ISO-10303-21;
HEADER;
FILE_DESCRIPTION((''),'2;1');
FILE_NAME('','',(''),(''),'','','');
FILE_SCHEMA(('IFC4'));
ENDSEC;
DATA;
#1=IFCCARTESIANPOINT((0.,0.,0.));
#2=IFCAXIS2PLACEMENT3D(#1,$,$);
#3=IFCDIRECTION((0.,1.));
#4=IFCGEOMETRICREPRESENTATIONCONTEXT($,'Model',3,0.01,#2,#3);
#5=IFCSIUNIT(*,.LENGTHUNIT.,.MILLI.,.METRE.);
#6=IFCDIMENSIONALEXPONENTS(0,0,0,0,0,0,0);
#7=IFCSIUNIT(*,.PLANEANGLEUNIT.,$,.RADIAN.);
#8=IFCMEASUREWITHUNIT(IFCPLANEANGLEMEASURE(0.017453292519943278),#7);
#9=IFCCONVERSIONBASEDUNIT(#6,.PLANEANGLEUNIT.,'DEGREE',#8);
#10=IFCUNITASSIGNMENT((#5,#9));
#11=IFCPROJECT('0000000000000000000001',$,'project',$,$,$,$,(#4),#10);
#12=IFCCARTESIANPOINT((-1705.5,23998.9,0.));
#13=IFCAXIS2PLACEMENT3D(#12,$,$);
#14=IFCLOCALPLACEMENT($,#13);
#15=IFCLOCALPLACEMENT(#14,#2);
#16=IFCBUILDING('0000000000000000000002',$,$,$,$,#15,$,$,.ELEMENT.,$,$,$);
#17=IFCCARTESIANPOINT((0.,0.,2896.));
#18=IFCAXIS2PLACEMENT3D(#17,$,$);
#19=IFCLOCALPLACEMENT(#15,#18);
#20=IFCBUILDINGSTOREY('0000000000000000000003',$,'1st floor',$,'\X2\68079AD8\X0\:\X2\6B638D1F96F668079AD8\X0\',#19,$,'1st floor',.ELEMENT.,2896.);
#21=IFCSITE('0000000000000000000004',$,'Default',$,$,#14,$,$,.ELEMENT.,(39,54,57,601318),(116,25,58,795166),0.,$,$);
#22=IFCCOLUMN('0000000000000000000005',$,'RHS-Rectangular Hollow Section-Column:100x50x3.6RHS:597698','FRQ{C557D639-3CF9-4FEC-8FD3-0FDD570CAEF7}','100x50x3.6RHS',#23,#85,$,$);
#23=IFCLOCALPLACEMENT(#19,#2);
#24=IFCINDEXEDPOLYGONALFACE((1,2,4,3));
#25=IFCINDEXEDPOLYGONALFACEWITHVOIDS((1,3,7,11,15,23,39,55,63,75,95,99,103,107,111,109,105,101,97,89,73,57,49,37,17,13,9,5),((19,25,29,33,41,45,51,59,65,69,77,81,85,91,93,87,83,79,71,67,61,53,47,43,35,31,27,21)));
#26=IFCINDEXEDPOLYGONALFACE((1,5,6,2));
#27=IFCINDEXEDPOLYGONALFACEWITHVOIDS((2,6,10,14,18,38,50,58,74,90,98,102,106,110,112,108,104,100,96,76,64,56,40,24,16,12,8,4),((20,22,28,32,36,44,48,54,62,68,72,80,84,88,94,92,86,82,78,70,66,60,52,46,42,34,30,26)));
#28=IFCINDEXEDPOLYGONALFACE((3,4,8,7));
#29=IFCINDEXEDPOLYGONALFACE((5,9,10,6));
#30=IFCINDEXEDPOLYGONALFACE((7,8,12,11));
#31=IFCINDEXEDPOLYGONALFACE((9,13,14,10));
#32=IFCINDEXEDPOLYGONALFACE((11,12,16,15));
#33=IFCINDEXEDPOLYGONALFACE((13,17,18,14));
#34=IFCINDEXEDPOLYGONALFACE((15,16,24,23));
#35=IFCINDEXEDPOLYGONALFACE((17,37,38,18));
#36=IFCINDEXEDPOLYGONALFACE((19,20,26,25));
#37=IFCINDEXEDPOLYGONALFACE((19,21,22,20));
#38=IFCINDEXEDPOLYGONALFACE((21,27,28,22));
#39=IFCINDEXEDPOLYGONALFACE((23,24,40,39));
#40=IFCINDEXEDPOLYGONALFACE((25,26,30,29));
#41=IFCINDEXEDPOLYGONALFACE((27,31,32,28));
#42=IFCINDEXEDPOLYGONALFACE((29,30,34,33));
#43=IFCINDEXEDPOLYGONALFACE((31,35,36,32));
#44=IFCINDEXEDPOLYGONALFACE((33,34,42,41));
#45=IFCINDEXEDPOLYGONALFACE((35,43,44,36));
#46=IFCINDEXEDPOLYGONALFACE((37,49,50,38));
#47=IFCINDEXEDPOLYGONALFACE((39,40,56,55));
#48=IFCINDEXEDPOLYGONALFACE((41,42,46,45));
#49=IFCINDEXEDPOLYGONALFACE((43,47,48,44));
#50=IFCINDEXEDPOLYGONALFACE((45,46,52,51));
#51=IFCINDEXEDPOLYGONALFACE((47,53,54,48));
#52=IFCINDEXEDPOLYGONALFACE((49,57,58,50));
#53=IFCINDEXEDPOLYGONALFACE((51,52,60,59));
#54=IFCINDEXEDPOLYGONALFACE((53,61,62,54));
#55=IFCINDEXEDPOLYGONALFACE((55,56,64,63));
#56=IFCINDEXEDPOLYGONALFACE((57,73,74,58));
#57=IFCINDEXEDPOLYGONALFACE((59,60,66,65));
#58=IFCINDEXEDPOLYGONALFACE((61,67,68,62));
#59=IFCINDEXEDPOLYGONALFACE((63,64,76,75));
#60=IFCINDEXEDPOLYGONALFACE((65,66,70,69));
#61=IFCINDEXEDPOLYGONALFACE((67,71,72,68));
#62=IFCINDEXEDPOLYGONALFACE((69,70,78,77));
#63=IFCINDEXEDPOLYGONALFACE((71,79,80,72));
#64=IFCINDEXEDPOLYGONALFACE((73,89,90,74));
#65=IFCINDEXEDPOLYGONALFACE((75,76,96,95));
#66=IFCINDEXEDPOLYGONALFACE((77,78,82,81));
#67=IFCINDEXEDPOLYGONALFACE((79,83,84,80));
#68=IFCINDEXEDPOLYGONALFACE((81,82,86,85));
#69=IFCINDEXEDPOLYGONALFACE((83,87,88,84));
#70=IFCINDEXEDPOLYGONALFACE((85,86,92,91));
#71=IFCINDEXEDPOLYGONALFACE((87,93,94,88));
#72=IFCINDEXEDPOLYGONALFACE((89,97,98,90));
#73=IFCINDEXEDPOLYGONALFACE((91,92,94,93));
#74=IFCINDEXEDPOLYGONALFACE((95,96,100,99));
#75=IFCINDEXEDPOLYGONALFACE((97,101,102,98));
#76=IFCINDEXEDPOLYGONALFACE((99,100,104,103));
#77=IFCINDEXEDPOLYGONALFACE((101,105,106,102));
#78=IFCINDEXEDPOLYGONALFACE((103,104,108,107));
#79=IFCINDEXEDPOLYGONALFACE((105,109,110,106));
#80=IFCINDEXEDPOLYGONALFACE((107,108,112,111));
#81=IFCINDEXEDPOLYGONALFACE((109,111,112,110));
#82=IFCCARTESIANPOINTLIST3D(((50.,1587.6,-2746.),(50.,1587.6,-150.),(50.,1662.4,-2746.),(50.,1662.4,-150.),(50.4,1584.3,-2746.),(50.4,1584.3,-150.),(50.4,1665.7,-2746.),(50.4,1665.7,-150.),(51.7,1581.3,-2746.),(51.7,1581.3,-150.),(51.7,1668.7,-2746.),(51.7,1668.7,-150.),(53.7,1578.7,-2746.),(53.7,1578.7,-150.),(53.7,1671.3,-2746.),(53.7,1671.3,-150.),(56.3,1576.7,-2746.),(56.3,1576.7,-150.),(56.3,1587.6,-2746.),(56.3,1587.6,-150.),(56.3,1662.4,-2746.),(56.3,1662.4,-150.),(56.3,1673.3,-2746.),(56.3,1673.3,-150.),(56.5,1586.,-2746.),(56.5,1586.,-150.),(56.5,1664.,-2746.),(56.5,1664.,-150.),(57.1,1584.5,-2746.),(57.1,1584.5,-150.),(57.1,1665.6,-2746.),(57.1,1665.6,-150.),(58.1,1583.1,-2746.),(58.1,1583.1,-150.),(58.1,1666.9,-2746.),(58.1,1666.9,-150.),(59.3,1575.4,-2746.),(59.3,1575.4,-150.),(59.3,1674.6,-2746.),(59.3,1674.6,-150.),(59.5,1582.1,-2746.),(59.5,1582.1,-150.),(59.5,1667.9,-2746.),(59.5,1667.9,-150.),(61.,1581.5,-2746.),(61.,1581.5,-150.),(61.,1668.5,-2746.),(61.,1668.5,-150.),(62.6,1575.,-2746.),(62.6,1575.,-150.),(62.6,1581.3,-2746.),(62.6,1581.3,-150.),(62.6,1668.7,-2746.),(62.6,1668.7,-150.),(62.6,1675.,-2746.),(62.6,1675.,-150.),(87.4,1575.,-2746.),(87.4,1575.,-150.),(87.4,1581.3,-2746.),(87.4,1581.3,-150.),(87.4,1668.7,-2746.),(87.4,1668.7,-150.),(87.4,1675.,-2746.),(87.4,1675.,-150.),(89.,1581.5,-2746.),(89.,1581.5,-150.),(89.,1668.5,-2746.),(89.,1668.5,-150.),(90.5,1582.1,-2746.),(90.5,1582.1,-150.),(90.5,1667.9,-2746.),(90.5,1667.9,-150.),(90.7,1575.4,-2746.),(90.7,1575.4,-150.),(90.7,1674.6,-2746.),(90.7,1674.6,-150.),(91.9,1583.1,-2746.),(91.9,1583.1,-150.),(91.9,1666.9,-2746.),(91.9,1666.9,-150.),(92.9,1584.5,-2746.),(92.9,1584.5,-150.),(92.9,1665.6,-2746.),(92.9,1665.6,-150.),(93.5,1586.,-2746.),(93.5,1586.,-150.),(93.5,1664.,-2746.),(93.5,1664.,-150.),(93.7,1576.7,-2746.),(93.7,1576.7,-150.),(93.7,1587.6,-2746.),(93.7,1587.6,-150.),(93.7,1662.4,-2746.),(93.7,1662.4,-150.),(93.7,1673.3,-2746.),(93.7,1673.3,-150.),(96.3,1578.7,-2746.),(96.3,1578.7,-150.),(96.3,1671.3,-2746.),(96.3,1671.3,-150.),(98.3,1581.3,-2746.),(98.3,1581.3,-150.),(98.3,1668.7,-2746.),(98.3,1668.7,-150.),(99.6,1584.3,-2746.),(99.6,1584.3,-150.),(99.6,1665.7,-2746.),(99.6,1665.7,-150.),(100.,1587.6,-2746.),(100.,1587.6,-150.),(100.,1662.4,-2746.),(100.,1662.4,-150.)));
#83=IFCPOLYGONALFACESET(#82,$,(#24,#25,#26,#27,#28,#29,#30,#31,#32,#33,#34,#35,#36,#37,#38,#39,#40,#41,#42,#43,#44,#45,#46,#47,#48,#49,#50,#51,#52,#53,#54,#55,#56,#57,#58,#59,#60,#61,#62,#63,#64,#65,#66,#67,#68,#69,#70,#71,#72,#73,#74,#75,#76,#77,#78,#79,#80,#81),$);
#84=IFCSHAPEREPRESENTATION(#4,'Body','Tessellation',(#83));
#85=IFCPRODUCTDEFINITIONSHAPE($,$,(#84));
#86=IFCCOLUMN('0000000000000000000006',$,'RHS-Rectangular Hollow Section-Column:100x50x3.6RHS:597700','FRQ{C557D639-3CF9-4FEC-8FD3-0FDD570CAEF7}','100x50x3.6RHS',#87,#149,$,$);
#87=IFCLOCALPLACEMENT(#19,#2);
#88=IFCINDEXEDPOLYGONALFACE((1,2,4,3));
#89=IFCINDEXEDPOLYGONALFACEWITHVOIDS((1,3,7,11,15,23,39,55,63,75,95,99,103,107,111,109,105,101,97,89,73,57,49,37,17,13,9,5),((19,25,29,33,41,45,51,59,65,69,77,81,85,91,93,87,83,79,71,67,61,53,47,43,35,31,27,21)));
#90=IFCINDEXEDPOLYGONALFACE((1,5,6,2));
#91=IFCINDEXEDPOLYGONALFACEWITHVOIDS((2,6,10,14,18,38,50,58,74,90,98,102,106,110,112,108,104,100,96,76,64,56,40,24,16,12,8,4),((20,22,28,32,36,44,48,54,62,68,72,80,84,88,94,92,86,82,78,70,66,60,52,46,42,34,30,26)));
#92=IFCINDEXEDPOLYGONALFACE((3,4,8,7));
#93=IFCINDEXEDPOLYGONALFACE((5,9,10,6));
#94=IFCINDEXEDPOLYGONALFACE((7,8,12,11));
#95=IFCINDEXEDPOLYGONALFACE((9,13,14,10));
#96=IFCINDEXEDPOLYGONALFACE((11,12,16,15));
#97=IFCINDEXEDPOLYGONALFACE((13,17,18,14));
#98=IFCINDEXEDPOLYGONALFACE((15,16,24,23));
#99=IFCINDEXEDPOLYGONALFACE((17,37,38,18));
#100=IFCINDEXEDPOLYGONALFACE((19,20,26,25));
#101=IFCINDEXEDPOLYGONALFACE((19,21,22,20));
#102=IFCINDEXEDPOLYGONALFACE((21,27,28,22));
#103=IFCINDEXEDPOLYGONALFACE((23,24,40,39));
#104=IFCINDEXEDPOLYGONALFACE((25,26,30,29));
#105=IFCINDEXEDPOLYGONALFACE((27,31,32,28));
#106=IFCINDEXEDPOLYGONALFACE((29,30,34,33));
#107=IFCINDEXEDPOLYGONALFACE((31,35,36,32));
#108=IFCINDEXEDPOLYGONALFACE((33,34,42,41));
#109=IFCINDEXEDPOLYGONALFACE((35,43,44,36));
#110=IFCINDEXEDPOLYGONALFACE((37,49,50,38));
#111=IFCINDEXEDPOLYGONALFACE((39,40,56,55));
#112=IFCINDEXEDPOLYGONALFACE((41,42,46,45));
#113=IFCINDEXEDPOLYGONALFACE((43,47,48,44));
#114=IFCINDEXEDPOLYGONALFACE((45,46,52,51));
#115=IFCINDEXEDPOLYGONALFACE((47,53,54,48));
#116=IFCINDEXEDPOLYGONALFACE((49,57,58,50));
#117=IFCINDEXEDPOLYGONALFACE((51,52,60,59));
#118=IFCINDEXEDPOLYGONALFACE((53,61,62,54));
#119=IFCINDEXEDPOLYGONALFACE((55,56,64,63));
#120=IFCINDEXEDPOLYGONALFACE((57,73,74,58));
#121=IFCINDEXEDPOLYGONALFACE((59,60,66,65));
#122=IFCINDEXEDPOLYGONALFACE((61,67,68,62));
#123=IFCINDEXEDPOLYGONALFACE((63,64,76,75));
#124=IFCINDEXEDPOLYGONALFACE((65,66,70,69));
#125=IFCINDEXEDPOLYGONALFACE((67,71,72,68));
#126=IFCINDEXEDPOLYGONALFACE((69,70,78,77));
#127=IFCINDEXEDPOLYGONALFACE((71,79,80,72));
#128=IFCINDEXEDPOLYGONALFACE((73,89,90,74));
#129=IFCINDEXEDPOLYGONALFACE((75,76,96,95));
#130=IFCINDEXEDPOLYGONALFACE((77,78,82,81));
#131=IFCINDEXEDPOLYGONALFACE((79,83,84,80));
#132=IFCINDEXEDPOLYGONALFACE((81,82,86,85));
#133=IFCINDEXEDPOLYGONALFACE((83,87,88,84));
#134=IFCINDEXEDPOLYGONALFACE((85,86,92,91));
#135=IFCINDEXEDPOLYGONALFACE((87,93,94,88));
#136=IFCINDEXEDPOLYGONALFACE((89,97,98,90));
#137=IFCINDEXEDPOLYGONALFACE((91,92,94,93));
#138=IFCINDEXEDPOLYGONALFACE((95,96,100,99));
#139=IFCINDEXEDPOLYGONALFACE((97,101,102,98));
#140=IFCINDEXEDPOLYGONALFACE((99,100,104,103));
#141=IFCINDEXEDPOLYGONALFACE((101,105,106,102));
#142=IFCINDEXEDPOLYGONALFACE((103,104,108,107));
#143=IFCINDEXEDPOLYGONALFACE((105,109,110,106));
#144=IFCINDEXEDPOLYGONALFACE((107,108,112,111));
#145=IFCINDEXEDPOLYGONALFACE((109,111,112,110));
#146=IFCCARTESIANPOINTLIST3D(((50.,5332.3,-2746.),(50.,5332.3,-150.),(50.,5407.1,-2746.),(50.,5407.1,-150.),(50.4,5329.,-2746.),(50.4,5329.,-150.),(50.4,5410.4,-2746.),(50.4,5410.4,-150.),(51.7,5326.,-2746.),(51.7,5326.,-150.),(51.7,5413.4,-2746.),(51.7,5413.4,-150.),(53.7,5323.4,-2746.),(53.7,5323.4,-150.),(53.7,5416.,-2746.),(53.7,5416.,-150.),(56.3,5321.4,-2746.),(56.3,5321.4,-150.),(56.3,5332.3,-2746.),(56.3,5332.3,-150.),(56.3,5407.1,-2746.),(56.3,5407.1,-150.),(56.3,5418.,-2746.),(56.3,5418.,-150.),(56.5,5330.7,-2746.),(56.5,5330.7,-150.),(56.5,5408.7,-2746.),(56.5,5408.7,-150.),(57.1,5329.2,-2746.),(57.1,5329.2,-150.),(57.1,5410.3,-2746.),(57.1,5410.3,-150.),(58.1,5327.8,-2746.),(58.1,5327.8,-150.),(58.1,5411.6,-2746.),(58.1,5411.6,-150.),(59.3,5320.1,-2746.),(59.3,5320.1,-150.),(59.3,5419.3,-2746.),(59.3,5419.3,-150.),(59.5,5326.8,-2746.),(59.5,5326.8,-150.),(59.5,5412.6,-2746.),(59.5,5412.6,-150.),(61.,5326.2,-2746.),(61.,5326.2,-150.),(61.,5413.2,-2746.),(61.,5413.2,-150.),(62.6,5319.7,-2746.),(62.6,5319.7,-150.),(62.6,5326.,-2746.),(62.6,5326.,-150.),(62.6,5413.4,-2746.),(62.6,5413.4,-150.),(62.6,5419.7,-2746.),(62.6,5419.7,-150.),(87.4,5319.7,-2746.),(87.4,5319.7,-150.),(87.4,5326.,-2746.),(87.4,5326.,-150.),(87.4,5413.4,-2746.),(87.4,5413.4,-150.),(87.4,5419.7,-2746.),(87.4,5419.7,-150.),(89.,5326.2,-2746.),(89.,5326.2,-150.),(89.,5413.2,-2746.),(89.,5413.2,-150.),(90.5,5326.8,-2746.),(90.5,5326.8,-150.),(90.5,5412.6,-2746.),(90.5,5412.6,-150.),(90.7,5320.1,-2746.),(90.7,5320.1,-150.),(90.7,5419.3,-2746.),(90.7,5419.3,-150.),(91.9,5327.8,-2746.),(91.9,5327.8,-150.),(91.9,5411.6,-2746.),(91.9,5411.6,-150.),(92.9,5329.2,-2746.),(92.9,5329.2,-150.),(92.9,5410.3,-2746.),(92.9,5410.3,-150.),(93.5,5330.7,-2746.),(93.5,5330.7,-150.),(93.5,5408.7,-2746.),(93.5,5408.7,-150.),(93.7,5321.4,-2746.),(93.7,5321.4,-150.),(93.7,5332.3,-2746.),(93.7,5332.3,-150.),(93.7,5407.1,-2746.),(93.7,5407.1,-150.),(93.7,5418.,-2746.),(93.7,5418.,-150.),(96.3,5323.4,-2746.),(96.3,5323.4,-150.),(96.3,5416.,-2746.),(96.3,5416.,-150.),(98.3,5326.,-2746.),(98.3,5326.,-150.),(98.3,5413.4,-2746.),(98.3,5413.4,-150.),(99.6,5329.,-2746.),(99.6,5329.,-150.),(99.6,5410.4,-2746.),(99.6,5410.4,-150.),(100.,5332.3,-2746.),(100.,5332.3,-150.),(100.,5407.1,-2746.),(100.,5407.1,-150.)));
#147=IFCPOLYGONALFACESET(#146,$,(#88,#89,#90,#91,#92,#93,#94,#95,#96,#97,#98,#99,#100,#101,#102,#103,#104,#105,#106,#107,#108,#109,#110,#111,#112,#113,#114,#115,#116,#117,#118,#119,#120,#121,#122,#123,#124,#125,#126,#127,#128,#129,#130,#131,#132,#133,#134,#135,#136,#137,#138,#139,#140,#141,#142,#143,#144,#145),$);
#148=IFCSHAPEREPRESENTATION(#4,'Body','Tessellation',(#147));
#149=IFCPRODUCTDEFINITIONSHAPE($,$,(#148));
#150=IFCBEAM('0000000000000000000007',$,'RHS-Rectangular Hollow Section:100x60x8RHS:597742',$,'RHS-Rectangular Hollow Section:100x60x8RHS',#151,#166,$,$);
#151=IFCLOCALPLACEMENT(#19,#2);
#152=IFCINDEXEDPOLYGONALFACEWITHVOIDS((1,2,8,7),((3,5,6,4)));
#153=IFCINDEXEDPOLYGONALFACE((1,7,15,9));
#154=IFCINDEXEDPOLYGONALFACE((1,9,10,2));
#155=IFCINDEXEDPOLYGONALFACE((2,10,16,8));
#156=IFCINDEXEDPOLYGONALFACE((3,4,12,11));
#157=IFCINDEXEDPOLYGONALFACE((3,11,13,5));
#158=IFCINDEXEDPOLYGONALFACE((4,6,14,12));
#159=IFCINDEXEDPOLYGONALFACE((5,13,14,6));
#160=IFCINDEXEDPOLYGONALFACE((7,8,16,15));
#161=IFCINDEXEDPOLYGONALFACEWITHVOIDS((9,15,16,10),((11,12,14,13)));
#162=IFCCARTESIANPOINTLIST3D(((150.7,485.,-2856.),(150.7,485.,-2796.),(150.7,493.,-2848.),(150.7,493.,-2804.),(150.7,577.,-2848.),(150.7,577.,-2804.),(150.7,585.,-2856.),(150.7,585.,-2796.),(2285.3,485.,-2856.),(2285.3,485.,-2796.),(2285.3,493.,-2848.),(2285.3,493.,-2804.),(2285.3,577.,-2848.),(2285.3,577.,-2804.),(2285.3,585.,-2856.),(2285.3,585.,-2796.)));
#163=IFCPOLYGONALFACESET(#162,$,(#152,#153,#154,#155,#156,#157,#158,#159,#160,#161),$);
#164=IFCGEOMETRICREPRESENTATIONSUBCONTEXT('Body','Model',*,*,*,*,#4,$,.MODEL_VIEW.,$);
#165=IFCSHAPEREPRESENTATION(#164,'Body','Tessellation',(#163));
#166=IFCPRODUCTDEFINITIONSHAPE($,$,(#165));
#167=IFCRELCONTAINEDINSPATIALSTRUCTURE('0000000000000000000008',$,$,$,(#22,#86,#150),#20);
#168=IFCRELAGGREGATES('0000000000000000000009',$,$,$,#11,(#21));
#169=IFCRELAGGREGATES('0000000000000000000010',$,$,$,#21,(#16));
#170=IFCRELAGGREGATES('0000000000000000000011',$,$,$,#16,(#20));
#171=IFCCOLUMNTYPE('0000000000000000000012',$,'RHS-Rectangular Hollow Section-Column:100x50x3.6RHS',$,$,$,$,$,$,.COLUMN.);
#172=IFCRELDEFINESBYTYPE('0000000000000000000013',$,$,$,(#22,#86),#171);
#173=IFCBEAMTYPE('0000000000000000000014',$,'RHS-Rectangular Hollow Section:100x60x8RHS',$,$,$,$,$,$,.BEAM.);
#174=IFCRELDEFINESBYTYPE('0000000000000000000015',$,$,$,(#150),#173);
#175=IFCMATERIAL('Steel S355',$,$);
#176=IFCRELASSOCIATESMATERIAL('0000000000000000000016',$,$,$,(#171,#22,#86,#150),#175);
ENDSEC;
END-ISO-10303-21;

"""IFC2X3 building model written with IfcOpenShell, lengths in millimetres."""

from ifc_helpers import new_model, entity, si_unit, converted_unit, point, direction, frame, frame_2d, origin, origin_2d, place, context, subcontext, project, spatial, circle_curve, line_curve, trimmed, segment, composite_curve, rectangle, hollow_rectangle, outline, extrude, boolean, clip, halfspace, material, type_object, element, save


model = new_model("IFC2X3")

# Units and contexts
model_context = context("Model", 3, precision=0.01, world=origin(), true_north=direction((0.0, 1.0)))
body_context = subcontext(model_context, "Body", "Model", "MODEL_VIEW")
ifc_project = project(units=[si_unit("LENGTHUNIT", "METRE", prefix="MILLI"), converted_unit("PLANEANGLEUNIT", "DEGREE", entity("IfcPlaneAngleMeasure", 0.017453292519943278), si_unit("PLANEANGLEUNIT", "RADIAN"), dimensions=[0, 0, 0, 0, 0, 0, 0])], contexts=[model_context])

# Site, building, storey
site_placement = place(None, frame((-1705.5, 23998.9, 0.0)))
site = spatial("IfcSite", under=ifc_project, at=site_placement, Name="Default", CompositionType="ELEMENT", RefLatitude=(39, 54, 57, 601318), RefLongitude=(116, 25, 58, 795166), RefElevation=0.0)
building_placement = place(site_placement, origin())
building = spatial("IfcBuilding", under=site, at=building_placement, CompositionType="ELEMENT")
storey_placement = place(building_placement, frame((0.0, 0.0, 2896.0)))
storey = spatial("IfcBuildingStorey", under=building, at=storey_placement, Name="1st floor", ObjectType="标高:正负零标高", LongName="1st floor", CompositionType="ELEMENT", Elevation=2896.0)

# Shared definitions
ifc_material_1 = material(Name="Steel S355")

# Columns, openings
column_type_1 = type_object("IfcColumnType", Name="RHS-Rectangular Hollow Section-Column:100x50x3.6RHS", PredefinedType="COLUMN", material=ifc_material_1)
column_1_placement = place(storey_placement, frame((75.0, 1625.0, -19.1)))
column_1 = element("IfcColumn", 1, at=column_1_placement, inside=storey, type_object=column_type_1, material=ifc_material_1, Name="RHS-Rectangular Hollow Section-Column:100x50x3.6RHS:597698", Description="FRQ{C557D639-3CF9-4FEC-8FD3-0FDD570CAEF7}", ObjectType="100x50x3.6RHS", context=model_context, shape_type="Clipping", body=[
    clip(clip(extrude(hollow_rectangle(XDim=50.0, YDim=100.0, WallThickness=6.3, InnerFilletRadius=6.3, OuterFilletRadius=12.6, at=origin_2d()), origin(), (0.0, 0.0, -1.0), 2782.8), halfspace(frame((-75.0, -1625.0, -2726.9), z_axis=(0.0, 0.0, 1.0), x_axis=(1.0, 0.0, 0.0)), True)), halfspace(frame((-75.0, -1625.0, -55.9), z_axis=(0.0, 0.0, -1.0), x_axis=(-1.0, 0.0, 0.0)), True)),
])
opening_1_placement = place(column_1_placement, frame((0.0, -150.1, -130.9), z_axis=(0.0, 1.0, 0.0), x_axis=(-1.0, 0.0, 0.0)))
element("IfcOpeningElement", 2, at=opening_1_placement, cuts=column_1, ObjectType="Opening", context=model_context, shape_type="SweptSolid", body=[
    extrude(outline(composite_curve([segment(trimmed(circle_curve(frame_2d((43.0, 32.0), x_axis=(1.0, 0.0)), 32.0), [point((43.0, 0.0))], [point((75.0, 32.0))], True, "CARTESIAN"), True, "CONTINUOUS"), segment(trimmed(line_curve((75.0, 32.0), (0.0, 1.0), 86.0), [point((75.0, 32.0))], [point((75.0, 118.0))], True, "CARTESIAN"), True, "CONTINUOUS"), segment(trimmed(circle_curve(frame_2d((43.0, 118.0), x_axis=(1.0, 0.0)), 32.0), [point((75.0, 118.0))], [point((43.0, 150.0))], True, "CARTESIAN"), True, "CONTINUOUS"), segment(trimmed(line_curve((43.0, 150.0), (-1.0, 0.0), 86.0), [point((43.0, 150.0))], [point((-43.0, 150.0))], True, "CARTESIAN"), True, "CONTINUOUS"), segment(trimmed(circle_curve(frame_2d((-43.0, 118.0), x_axis=(1.0, 0.0)), 32.0), [point((-43.0, 150.0))], [point((-75.0, 118.0))], True, "CARTESIAN"), True, "CONTINUOUS"), segment(trimmed(line_curve((-75.0, 118.0), (0.0, -1.0), 86.0), [point((-75.0, 118.0))], [point((-75.0, 32.0))], True, "CARTESIAN"), True, "CONTINUOUS"), segment(trimmed(circle_curve(frame_2d((-43.0, 32.0), x_axis=(1.0, 0.0)), 32.0), [point((-75.0, 32.0))], [point((-43.0, 0.0))], True, "CARTESIAN"), True, "CONTINUOUS"), segment(trimmed(line_curve((-43.0, 0.0), (1.0, 0.0), 86.0), [point((-43.0, 0.0))], [point((43.0, 0.0))], True, "CARTESIAN"), True, "CONTINUOUS")], self_intersect="UNKNOWN")), origin(), (0.0, 0.0, 1.0), 300.2),
])
column_2_placement = place(storey_placement, frame((75.0, 5369.7, -19.1)))
column_2 = element("IfcColumn", 3, at=column_2_placement, inside=storey, type_object=column_type_1, material=ifc_material_1, Name="RHS-Rectangular Hollow Section-Column:100x50x3.6RHS:597700", Description="FRQ{C557D639-3CF9-4FEC-8FD3-0FDD570CAEF7}", ObjectType="100x50x3.6RHS", context=model_context, shape_type="Clipping", body=[
    clip(clip(extrude(hollow_rectangle(XDim=50.0, YDim=100.0, WallThickness=6.3, InnerFilletRadius=6.3, OuterFilletRadius=12.6, at=origin_2d()), origin(), (0.0, 0.0, -1.0), 2782.8), halfspace(frame((-75.0, -5369.7, -55.9), z_axis=(0.0, 0.0, -1.0), x_axis=(-1.0, 0.0, 0.0)), True)), halfspace(frame((-75.0, -5369.7, -2726.9), z_axis=(0.0, 0.0, 1.0), x_axis=(1.0, 0.0, 0.0)), True)),
])
opening_2_placement = place(column_2_placement, frame((0.0, -150.1, -130.9), z_axis=(0.0, 1.0, 0.0), x_axis=(-1.0, 0.0, 0.0)))
element("IfcOpeningElement", 4, at=opening_2_placement, cuts=column_2, ObjectType="Opening", context=model_context, shape_type="SweptSolid", body=[
    extrude(outline(composite_curve([segment(trimmed(circle_curve(frame_2d((43.0, 32.0), x_axis=(1.0, 0.0)), 32.0), [point((43.0, 0.0))], [point((75.0, 32.0))], True, "CARTESIAN"), True, "CONTINUOUS"), segment(trimmed(line_curve((75.0, 32.0), (0.0, 1.0), 86.0), [point((75.0, 32.0))], [point((75.0, 118.0))], True, "CARTESIAN"), True, "CONTINUOUS"), segment(trimmed(circle_curve(frame_2d((43.0, 118.0), x_axis=(1.0, 0.0)), 32.0), [point((75.0, 118.0))], [point((43.0, 150.0))], True, "CARTESIAN"), True, "CONTINUOUS"), segment(trimmed(line_curve((43.0, 150.0), (-1.0, 0.0), 86.0), [point((43.0, 150.0))], [point((-43.0, 150.0))], True, "CARTESIAN"), True, "CONTINUOUS"), segment(trimmed(circle_curve(frame_2d((-43.0, 118.0), x_axis=(1.0, 0.0)), 32.0), [point((-43.0, 150.0))], [point((-75.0, 118.0))], True, "CARTESIAN"), True, "CONTINUOUS"), segment(trimmed(line_curve((-75.0, 118.0), (0.0, -1.0), 86.0), [point((-75.0, 118.0))], [point((-75.0, 32.0))], True, "CARTESIAN"), True, "CONTINUOUS"), segment(trimmed(circle_curve(frame_2d((-43.0, 32.0), x_axis=(1.0, 0.0)), 32.0), [point((-75.0, 32.0))], [point((-43.0, 0.0))], True, "CARTESIAN"), True, "CONTINUOUS"), segment(trimmed(line_curve((-43.0, 0.0), (1.0, 0.0), 86.0), [point((-43.0, 0.0))], [point((43.0, 0.0))], True, "CARTESIAN"), True, "CONTINUOUS")], self_intersect="UNKNOWN")), origin(), (0.0, 0.0, 1.0), 300.2),
])

# Beam
beam_type_1 = type_object("IfcBeamType", Name="RHS-Rectangular Hollow Section:100x60x8RHS", PredefinedType="BEAM")
beam_1_placement = place(storey_placement, frame((150.7, 585.0, -2826.0)))
element("IfcBeam", 5, at=beam_1_placement, inside=storey, type_object=beam_type_1, material=ifc_material_1, Name="RHS-Rectangular Hollow Section:100x60x8RHS:597742", ObjectType="RHS-Rectangular Hollow Section:100x60x8RHS", context=body_context, shape_type="SweptSolid", body=[
    boolean("DIFFERENCE", extrude(rectangle(XDim=60.0, YDim=100.0, at=frame_2d((0.0, 0.0), x_axis=(1.0, 0.0))), frame((0.0, -50.0, 0.0), z_axis=(1.0, 0.0, 0.0), x_axis=(0.0, 0.0, -1.0)), (0.0, 0.0, 1.0), 2134.6), extrude(rectangle(XDim=44.0, YDim=84.0, at=frame_2d((0.0, 0.0), x_axis=(0.0, 1.0))), frame((2134.6, -50.0, 0.0), z_axis=(-1.0, 0.0, 0.0), x_axis=(0.0, 1.0, 0.0)), (0.0, 0.0, 1.0), 2134.6)),
])

save(model, "model.ifc")
